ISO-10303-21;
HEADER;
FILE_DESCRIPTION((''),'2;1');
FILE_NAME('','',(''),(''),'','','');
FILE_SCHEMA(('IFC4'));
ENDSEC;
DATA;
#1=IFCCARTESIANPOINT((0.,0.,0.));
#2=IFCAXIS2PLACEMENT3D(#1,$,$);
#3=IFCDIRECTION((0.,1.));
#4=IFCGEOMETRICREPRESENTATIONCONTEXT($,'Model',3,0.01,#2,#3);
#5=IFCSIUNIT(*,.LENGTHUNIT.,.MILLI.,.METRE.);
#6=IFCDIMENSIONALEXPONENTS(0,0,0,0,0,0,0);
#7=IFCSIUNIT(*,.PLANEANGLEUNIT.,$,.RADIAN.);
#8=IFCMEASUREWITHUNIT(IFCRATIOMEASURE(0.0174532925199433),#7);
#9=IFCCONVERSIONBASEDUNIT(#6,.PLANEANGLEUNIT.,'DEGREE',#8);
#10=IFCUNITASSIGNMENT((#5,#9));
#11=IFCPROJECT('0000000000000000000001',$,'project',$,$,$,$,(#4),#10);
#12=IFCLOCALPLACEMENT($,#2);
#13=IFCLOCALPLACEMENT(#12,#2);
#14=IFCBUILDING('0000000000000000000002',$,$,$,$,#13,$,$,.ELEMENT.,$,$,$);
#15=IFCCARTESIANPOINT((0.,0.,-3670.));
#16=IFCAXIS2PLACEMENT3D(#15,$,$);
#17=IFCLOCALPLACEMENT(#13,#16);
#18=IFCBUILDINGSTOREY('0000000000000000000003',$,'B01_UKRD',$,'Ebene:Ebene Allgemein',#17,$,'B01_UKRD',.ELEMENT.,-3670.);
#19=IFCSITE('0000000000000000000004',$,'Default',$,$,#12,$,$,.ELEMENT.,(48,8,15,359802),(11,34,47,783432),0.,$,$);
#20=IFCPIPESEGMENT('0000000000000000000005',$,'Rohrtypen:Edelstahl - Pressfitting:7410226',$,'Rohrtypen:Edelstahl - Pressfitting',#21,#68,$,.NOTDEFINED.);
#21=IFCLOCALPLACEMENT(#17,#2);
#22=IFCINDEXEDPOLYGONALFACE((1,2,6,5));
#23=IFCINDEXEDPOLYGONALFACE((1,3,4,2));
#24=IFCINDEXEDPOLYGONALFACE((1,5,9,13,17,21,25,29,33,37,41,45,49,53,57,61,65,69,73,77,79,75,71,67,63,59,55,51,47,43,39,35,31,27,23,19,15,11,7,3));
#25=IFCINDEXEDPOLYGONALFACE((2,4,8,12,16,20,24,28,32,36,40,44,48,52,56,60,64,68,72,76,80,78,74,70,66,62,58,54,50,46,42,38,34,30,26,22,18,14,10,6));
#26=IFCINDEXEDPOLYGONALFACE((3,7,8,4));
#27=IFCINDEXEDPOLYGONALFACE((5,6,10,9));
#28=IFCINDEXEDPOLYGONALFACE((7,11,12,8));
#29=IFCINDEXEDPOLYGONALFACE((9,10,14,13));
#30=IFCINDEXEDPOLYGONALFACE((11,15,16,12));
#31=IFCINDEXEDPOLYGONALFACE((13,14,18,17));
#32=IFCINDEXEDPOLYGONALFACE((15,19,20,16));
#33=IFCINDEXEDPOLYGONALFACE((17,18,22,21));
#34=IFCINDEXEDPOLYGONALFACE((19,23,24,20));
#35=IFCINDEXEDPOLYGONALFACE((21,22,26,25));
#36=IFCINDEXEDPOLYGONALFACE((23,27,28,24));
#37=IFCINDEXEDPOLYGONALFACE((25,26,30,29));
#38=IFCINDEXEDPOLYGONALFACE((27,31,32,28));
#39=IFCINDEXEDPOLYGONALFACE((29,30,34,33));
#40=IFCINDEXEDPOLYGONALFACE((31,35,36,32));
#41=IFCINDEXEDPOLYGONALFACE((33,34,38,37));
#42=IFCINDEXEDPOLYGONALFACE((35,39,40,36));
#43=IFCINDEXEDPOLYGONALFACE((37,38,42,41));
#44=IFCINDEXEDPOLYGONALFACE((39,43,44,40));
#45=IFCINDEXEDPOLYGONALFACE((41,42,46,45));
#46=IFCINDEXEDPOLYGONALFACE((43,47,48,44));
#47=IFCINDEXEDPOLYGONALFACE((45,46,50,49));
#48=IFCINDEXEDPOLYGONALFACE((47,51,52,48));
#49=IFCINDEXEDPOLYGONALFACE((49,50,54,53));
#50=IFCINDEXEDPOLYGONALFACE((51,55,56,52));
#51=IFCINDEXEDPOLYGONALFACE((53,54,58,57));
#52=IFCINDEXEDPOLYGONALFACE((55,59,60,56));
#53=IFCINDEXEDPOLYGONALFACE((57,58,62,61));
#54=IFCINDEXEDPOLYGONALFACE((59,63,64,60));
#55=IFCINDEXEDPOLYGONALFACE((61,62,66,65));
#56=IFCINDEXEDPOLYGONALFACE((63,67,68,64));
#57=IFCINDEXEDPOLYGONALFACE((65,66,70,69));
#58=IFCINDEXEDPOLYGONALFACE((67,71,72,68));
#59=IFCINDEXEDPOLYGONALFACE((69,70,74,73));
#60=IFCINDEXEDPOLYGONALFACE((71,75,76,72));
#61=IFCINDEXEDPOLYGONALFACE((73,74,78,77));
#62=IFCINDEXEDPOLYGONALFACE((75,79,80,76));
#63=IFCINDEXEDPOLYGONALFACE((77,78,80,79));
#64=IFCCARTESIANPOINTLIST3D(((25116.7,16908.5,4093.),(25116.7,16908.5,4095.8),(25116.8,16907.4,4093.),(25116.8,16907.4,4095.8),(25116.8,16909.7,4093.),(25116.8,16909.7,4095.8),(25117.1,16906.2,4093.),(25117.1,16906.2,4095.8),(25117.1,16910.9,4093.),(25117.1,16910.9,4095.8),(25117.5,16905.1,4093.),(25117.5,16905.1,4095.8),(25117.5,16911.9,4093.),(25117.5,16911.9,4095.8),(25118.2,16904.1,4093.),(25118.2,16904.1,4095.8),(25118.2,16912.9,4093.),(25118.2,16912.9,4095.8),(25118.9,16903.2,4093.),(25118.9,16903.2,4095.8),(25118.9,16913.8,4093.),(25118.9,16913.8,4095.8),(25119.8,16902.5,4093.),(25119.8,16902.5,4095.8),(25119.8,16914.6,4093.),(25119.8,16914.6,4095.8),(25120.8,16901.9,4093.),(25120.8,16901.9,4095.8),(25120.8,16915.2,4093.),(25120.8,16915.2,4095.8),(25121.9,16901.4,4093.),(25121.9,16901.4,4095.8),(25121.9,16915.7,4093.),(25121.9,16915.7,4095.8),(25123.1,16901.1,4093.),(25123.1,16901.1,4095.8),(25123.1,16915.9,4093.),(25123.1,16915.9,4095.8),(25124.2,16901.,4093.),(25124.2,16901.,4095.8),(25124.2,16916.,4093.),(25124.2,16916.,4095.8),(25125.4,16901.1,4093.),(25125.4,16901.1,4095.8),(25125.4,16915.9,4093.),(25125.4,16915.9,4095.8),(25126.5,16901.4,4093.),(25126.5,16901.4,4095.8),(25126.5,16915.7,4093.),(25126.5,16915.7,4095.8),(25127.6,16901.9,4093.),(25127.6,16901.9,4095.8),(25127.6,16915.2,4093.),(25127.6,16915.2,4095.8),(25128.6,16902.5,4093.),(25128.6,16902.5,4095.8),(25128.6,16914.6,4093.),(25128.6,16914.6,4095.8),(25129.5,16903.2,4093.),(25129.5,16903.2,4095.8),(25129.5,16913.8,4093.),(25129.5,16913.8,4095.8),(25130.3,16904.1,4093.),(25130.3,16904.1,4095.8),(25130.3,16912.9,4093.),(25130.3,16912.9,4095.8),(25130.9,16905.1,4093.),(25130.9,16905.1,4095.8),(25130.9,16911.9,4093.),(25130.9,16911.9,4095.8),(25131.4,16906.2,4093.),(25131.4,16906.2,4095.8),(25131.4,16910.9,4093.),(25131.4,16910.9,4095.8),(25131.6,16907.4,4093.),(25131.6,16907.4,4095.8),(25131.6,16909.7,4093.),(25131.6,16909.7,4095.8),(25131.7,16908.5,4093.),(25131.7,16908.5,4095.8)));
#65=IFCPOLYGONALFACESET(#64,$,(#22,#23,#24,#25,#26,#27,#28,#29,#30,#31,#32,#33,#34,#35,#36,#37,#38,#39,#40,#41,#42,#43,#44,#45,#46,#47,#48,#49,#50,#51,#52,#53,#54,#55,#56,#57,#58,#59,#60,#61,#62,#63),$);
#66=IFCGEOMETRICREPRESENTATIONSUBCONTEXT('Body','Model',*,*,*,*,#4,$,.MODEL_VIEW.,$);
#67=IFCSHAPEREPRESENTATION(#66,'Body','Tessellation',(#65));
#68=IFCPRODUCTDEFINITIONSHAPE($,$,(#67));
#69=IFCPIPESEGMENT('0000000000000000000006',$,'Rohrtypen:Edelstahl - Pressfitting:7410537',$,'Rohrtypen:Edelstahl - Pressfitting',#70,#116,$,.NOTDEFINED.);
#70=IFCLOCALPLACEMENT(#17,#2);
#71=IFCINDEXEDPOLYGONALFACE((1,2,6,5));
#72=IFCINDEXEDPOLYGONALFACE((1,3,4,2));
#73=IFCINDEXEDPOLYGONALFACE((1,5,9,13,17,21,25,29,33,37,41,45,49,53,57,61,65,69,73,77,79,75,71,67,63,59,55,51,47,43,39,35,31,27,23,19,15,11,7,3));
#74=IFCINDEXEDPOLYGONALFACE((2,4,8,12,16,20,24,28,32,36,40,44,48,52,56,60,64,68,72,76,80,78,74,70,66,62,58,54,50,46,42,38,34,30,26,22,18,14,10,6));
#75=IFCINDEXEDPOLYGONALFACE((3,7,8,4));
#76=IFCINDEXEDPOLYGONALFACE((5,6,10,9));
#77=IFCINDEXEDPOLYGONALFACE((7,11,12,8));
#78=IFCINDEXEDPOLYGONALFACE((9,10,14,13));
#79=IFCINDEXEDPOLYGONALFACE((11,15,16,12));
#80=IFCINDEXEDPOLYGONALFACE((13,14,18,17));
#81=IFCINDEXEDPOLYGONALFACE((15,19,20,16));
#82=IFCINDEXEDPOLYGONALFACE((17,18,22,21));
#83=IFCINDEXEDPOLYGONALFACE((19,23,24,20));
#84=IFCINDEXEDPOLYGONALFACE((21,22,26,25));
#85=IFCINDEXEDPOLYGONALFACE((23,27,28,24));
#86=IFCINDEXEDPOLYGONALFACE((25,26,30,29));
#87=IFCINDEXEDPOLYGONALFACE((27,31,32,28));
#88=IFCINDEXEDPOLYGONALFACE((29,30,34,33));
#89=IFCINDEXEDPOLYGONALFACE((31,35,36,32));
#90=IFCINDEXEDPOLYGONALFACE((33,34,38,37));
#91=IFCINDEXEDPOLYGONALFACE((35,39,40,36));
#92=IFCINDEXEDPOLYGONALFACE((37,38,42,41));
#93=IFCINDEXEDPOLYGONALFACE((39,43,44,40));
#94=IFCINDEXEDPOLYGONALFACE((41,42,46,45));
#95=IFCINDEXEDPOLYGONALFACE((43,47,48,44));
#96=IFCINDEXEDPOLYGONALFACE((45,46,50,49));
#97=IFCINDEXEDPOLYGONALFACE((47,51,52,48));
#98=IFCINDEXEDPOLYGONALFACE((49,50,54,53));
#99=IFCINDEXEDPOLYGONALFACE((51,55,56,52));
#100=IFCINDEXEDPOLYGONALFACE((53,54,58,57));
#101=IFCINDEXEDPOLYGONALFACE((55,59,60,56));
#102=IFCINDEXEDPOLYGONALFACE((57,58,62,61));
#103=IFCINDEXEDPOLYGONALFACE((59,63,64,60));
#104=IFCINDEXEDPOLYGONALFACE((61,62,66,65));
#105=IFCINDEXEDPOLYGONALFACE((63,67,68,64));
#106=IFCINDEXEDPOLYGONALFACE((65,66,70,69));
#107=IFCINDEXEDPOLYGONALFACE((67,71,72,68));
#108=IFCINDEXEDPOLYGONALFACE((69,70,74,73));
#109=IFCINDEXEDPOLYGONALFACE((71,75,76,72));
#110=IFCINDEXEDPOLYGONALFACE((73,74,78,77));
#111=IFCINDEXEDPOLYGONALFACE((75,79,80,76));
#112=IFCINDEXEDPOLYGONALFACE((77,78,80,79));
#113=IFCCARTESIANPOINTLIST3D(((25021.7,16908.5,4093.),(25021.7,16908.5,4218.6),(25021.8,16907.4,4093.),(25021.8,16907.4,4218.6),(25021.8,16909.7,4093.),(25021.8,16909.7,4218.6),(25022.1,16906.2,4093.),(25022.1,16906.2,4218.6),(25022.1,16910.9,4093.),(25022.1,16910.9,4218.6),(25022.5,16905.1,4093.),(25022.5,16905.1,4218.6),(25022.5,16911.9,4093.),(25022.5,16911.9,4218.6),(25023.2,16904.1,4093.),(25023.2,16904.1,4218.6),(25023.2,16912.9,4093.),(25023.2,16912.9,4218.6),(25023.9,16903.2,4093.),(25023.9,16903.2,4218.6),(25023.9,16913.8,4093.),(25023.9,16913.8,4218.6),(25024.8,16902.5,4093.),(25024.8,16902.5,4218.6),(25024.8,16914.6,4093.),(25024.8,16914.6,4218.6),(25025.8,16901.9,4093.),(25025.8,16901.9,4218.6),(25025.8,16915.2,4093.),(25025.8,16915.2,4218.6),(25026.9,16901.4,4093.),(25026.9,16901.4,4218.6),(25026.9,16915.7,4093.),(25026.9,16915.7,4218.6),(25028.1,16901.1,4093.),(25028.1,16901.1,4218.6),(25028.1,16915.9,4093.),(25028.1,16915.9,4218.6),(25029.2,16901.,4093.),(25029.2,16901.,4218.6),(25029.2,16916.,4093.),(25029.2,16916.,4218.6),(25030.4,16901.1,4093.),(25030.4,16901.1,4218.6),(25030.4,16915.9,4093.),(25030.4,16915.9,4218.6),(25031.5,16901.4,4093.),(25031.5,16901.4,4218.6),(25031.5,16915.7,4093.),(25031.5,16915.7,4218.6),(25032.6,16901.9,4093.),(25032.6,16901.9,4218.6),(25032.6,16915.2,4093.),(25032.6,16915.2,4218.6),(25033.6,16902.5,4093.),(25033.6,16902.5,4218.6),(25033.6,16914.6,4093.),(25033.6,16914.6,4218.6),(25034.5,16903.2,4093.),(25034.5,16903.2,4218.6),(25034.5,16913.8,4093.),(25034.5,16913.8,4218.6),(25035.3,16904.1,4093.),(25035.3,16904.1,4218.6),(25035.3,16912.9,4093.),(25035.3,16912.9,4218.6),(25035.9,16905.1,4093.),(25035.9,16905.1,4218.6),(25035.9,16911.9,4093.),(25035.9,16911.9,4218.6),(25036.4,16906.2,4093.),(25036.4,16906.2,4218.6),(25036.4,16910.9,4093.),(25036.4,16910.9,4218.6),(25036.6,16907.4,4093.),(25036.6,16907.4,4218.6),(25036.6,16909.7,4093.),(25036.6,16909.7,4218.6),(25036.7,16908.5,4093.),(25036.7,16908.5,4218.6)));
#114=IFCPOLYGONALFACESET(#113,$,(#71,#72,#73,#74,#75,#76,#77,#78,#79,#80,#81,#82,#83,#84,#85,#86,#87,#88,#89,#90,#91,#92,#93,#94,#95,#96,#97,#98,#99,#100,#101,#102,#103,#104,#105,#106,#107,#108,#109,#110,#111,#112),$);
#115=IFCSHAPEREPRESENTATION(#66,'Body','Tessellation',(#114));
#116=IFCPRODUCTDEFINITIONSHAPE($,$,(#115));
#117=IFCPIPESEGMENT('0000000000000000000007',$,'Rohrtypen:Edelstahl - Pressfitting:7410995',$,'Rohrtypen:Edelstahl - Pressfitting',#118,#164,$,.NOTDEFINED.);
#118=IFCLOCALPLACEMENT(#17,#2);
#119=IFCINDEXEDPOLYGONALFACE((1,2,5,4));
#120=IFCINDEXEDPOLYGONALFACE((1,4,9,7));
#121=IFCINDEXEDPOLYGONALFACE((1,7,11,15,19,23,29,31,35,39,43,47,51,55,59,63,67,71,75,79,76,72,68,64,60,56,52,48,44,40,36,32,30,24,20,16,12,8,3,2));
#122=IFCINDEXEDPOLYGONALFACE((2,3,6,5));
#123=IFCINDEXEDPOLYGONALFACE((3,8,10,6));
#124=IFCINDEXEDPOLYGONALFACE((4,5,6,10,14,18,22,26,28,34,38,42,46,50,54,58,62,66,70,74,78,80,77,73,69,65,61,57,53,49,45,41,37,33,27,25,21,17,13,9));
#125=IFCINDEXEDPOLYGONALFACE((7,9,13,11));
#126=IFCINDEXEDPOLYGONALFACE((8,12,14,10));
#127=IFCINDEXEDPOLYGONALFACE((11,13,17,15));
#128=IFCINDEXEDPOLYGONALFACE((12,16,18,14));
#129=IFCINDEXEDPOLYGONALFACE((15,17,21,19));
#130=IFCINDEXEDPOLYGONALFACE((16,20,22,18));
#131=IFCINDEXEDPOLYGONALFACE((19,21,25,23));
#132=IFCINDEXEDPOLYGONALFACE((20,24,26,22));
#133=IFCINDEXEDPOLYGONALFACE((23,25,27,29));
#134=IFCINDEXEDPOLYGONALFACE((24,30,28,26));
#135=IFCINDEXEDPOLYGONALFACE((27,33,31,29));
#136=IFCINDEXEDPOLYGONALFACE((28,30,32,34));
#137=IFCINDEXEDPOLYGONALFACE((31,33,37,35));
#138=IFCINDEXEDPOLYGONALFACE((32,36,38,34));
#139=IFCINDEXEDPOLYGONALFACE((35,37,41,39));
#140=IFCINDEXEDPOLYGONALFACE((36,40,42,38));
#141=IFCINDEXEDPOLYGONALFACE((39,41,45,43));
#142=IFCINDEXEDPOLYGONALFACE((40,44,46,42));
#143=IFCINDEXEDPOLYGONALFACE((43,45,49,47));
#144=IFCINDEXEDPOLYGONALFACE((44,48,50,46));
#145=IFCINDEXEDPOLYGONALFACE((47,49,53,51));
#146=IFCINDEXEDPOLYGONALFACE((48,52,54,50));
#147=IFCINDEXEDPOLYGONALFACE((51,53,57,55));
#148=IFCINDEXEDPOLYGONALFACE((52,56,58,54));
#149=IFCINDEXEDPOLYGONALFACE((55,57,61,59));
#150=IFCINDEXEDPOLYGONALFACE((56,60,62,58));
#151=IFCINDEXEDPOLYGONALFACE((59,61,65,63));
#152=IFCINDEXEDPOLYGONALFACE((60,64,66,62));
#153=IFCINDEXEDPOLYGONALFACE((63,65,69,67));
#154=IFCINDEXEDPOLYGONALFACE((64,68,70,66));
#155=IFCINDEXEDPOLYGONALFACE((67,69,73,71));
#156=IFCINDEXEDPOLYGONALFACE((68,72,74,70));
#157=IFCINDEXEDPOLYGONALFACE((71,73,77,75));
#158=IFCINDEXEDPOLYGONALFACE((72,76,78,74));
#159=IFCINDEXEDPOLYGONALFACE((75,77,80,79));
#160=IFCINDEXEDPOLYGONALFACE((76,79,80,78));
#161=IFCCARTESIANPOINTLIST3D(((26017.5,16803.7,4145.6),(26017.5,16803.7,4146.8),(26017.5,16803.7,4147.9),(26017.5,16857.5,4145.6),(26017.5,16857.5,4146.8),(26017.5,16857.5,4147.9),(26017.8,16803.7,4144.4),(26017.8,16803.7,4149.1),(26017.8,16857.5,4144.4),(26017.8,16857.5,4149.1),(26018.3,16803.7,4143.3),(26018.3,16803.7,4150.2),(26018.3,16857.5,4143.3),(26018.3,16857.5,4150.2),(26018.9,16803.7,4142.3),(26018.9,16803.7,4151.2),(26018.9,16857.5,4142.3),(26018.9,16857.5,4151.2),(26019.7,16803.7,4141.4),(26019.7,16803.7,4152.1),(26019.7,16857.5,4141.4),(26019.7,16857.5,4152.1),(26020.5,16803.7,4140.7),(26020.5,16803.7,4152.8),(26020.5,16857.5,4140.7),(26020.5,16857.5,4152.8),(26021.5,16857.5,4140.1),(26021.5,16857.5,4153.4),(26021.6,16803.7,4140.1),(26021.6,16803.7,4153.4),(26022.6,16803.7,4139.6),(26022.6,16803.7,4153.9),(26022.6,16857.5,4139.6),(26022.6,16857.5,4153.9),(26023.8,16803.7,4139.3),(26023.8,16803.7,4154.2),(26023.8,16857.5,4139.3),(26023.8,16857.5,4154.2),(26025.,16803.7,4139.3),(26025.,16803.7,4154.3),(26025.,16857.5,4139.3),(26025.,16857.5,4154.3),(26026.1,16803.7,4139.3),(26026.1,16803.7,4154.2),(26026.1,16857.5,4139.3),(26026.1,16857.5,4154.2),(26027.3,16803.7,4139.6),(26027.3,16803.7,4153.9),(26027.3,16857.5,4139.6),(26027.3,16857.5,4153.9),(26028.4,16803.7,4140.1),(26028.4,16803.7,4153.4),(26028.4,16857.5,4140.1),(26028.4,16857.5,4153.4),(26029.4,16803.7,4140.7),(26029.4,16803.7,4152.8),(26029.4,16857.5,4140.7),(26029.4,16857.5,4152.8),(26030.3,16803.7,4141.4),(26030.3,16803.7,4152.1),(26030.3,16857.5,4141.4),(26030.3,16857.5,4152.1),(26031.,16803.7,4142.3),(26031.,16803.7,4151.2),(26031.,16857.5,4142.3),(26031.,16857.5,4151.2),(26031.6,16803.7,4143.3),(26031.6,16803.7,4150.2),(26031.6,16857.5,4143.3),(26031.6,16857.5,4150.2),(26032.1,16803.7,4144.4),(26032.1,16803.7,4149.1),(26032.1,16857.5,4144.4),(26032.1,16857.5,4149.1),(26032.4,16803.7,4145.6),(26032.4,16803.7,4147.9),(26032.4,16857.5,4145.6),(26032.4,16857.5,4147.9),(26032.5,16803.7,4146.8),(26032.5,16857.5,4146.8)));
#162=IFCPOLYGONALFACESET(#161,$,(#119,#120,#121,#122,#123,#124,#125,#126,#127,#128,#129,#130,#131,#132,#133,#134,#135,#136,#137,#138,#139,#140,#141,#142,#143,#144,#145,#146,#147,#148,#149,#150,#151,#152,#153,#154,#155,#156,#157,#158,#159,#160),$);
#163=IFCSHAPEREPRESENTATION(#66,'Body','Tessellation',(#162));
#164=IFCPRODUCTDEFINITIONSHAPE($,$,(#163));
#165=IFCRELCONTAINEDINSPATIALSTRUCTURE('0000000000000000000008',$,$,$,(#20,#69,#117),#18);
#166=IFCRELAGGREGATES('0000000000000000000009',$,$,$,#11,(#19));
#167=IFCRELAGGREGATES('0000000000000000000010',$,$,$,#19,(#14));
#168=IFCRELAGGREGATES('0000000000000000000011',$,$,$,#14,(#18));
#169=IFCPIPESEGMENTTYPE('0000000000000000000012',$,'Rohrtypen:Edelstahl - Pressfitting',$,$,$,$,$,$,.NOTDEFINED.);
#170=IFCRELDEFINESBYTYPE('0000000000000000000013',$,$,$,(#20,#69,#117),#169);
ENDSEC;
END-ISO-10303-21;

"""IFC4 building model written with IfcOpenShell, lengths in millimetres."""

from ifc_helpers import new_model, entity, si_unit, converted_unit, direction, frame, origin, place, context, subcontext, project, spatial, indexed_curve, outline, extrude, type_object, element, save


model = new_model("IFC4")

# Units and contexts
model_context = context("Model", 3, precision=0.01, world=origin(), true_north=direction((0.0, 1.0)))
body_context = subcontext(model_context, "Body", "Model", "MODEL_VIEW")
ifc_project = project(units=[si_unit("LENGTHUNIT", "METRE", prefix="MILLI"), converted_unit("PLANEANGLEUNIT", "DEGREE", entity("IfcRatioMeasure", 0.0174532925199433), si_unit("PLANEANGLEUNIT", "RADIAN"), dimensions=[0, 0, 0, 0, 0, 0, 0])], contexts=[model_context])

# Site, building, storey
site_placement = place(None, origin())
site = spatial("IfcSite", under=ifc_project, at=site_placement, Name="Default", CompositionType="ELEMENT", RefLatitude=(48, 8, 15, 359802), RefLongitude=(11, 34, 47, 783432), RefElevation=0.0)
building_placement = place(site_placement, origin())
building = spatial("IfcBuilding", under=site, at=building_placement, CompositionType="ELEMENT")
storey_placement = place(building_placement, frame((0.0, 0.0, -3670.0)))
storey = spatial("IfcBuildingStorey", under=building, at=storey_placement, Name="B01_UKRD", ObjectType="Ebene:Ebene Allgemein", LongName="B01_UKRD", CompositionType="ELEMENT", Elevation=-3670.0)

# Pipe segments
pipe_segment_type = type_object("IfcPipeSegmentType", Name="Rohrtypen:Edelstahl - Pressfitting", PredefinedType="NOTDEFINED")
pipe_segment_1_placement = place(storey_placement, origin())
element("IfcPipeSegment", 1, at=pipe_segment_1_placement, inside=storey, type_object=pipe_segment_type, Name="Rohrtypen:Edelstahl - Pressfitting:7410226", ObjectType="Rohrtypen:Edelstahl - Pressfitting", PredefinedType="NOTDEFINED", context=body_context, shape_type="SweptSolid", body=[
    extrude(outline(indexed_curve([(7.5, 0.0), (7.4, 1.2), (7.1, 2.3), (6.7, 3.4), (6.1, 4.4), (5.3, 5.3), (4.4, 6.1), (3.4, 6.7), (2.3, 7.1), (1.2, 7.4), (0.0, 7.5), (-1.2, 7.4), (-2.3, 7.1), (-3.4, 6.7), (-4.4, 6.1), (-5.3, 5.3), (-6.1, 4.4), (-6.7, 3.4), (-7.1, 2.3), (-7.4, 1.2), (-7.5, 0.0), (-7.4, -1.2), (-7.1, -2.3), (-6.7, -3.4), (-6.1, -4.4), (-5.3, -5.3), (-4.4, -6.1), (-3.4, -6.7), (-2.3, -7.1), (-1.2, -7.4), (0.0, -7.5), (1.2, -7.4), (2.3, -7.1), (3.4, -6.7), (4.4, -6.1), (5.3, -5.3), (6.1, -4.4), (6.7, -3.4), (7.1, -2.3), (7.4, -1.2), (7.5, 0.0)], self_intersect=False)), frame((25124.2, 16908.5, 4093.0), z_axis=(0.0, 0.0, 1.0), x_axis=(-1.0, 0.0, 0.0)), (0.0, 0.0, 1.0), 2.8),
])
pipe_segment_2_placement = place(storey_placement, origin())
element("IfcPipeSegment", 2, at=pipe_segment_2_placement, inside=storey, type_object=pipe_segment_type, Name="Rohrtypen:Edelstahl - Pressfitting:7410537", ObjectType="Rohrtypen:Edelstahl - Pressfitting", PredefinedType="NOTDEFINED", context=body_context, shape_type="SweptSolid", body=[
    extrude(outline(indexed_curve([(7.5, 0.0), (7.4, 1.2), (7.1, 2.3), (6.7, 3.4), (6.1, 4.4), (5.3, 5.3), (4.4, 6.1), (3.4, 6.7), (2.3, 7.1), (1.2, 7.4), (0.0, 7.5), (-1.2, 7.4), (-2.3, 7.1), (-3.4, 6.7), (-4.4, 6.1), (-5.3, 5.3), (-6.1, 4.4), (-6.7, 3.4), (-7.1, 2.3), (-7.4, 1.2), (-7.5, 0.0), (-7.4, -1.2), (-7.1, -2.3), (-6.7, -3.4), (-6.1, -4.4), (-5.3, -5.3), (-4.4, -6.1), (-3.4, -6.7), (-2.3, -7.1), (-1.2, -7.4), (0.0, -7.5), (1.2, -7.4), (2.3, -7.1), (3.4, -6.7), (4.4, -6.1), (5.3, -5.3), (6.1, -4.4), (6.7, -3.4), (7.1, -2.3), (7.4, -1.2), (7.5, 0.0)], self_intersect=False)), frame((25029.2, 16908.5, 4093.0), z_axis=(0.0, 0.0, 1.0), x_axis=(-1.0, 0.0, 0.0)), (0.0, 0.0, 1.0), 125.6),
])
pipe_segment_3_placement = place(storey_placement, origin())
element("IfcPipeSegment", 3, at=pipe_segment_3_placement, inside=storey, type_object=pipe_segment_type, Name="Rohrtypen:Edelstahl - Pressfitting:7410995", ObjectType="Rohrtypen:Edelstahl - Pressfitting", PredefinedType="NOTDEFINED", context=body_context, shape_type="SweptSolid", body=[
    extrude(outline(indexed_curve([(7.5, 0.0), (7.4, 1.2), (7.1, 2.3), (6.7, 3.4), (6.1, 4.4), (5.3, 5.3), (4.4, 6.1), (3.4, 6.7), (2.3, 7.1), (1.2, 7.4), (0.0, 7.5), (-1.2, 7.4), (-2.3, 7.1), (-3.4, 6.7), (-4.4, 6.1), (-5.3, 5.3), (-6.1, 4.4), (-6.7, 3.4), (-7.1, 2.3), (-7.4, 1.2), (-7.5, 0.0), (-7.4, -1.2), (-7.1, -2.3), (-6.7, -3.4), (-6.1, -4.4), (-5.3, -5.3), (-4.4, -6.1), (-3.4, -6.7), (-2.3, -7.1), (-1.2, -7.4), (0.0, -7.5), (1.2, -7.4), (2.3, -7.1), (3.4, -6.7), (4.4, -6.1), (5.3, -5.3), (6.1, -4.4), (6.7, -3.4), (7.1, -2.3), (7.4, -1.2), (7.5, 0.0)], self_intersect=False)), frame((26025.0, 16803.7, 4146.8), z_axis=(-0.000008, 1.0, 0.0), x_axis=(-1.0, -0.000008, 0.0)), (0.0, 0.0, 1.0), 53.8),
])

save(model, "model.ifc")
